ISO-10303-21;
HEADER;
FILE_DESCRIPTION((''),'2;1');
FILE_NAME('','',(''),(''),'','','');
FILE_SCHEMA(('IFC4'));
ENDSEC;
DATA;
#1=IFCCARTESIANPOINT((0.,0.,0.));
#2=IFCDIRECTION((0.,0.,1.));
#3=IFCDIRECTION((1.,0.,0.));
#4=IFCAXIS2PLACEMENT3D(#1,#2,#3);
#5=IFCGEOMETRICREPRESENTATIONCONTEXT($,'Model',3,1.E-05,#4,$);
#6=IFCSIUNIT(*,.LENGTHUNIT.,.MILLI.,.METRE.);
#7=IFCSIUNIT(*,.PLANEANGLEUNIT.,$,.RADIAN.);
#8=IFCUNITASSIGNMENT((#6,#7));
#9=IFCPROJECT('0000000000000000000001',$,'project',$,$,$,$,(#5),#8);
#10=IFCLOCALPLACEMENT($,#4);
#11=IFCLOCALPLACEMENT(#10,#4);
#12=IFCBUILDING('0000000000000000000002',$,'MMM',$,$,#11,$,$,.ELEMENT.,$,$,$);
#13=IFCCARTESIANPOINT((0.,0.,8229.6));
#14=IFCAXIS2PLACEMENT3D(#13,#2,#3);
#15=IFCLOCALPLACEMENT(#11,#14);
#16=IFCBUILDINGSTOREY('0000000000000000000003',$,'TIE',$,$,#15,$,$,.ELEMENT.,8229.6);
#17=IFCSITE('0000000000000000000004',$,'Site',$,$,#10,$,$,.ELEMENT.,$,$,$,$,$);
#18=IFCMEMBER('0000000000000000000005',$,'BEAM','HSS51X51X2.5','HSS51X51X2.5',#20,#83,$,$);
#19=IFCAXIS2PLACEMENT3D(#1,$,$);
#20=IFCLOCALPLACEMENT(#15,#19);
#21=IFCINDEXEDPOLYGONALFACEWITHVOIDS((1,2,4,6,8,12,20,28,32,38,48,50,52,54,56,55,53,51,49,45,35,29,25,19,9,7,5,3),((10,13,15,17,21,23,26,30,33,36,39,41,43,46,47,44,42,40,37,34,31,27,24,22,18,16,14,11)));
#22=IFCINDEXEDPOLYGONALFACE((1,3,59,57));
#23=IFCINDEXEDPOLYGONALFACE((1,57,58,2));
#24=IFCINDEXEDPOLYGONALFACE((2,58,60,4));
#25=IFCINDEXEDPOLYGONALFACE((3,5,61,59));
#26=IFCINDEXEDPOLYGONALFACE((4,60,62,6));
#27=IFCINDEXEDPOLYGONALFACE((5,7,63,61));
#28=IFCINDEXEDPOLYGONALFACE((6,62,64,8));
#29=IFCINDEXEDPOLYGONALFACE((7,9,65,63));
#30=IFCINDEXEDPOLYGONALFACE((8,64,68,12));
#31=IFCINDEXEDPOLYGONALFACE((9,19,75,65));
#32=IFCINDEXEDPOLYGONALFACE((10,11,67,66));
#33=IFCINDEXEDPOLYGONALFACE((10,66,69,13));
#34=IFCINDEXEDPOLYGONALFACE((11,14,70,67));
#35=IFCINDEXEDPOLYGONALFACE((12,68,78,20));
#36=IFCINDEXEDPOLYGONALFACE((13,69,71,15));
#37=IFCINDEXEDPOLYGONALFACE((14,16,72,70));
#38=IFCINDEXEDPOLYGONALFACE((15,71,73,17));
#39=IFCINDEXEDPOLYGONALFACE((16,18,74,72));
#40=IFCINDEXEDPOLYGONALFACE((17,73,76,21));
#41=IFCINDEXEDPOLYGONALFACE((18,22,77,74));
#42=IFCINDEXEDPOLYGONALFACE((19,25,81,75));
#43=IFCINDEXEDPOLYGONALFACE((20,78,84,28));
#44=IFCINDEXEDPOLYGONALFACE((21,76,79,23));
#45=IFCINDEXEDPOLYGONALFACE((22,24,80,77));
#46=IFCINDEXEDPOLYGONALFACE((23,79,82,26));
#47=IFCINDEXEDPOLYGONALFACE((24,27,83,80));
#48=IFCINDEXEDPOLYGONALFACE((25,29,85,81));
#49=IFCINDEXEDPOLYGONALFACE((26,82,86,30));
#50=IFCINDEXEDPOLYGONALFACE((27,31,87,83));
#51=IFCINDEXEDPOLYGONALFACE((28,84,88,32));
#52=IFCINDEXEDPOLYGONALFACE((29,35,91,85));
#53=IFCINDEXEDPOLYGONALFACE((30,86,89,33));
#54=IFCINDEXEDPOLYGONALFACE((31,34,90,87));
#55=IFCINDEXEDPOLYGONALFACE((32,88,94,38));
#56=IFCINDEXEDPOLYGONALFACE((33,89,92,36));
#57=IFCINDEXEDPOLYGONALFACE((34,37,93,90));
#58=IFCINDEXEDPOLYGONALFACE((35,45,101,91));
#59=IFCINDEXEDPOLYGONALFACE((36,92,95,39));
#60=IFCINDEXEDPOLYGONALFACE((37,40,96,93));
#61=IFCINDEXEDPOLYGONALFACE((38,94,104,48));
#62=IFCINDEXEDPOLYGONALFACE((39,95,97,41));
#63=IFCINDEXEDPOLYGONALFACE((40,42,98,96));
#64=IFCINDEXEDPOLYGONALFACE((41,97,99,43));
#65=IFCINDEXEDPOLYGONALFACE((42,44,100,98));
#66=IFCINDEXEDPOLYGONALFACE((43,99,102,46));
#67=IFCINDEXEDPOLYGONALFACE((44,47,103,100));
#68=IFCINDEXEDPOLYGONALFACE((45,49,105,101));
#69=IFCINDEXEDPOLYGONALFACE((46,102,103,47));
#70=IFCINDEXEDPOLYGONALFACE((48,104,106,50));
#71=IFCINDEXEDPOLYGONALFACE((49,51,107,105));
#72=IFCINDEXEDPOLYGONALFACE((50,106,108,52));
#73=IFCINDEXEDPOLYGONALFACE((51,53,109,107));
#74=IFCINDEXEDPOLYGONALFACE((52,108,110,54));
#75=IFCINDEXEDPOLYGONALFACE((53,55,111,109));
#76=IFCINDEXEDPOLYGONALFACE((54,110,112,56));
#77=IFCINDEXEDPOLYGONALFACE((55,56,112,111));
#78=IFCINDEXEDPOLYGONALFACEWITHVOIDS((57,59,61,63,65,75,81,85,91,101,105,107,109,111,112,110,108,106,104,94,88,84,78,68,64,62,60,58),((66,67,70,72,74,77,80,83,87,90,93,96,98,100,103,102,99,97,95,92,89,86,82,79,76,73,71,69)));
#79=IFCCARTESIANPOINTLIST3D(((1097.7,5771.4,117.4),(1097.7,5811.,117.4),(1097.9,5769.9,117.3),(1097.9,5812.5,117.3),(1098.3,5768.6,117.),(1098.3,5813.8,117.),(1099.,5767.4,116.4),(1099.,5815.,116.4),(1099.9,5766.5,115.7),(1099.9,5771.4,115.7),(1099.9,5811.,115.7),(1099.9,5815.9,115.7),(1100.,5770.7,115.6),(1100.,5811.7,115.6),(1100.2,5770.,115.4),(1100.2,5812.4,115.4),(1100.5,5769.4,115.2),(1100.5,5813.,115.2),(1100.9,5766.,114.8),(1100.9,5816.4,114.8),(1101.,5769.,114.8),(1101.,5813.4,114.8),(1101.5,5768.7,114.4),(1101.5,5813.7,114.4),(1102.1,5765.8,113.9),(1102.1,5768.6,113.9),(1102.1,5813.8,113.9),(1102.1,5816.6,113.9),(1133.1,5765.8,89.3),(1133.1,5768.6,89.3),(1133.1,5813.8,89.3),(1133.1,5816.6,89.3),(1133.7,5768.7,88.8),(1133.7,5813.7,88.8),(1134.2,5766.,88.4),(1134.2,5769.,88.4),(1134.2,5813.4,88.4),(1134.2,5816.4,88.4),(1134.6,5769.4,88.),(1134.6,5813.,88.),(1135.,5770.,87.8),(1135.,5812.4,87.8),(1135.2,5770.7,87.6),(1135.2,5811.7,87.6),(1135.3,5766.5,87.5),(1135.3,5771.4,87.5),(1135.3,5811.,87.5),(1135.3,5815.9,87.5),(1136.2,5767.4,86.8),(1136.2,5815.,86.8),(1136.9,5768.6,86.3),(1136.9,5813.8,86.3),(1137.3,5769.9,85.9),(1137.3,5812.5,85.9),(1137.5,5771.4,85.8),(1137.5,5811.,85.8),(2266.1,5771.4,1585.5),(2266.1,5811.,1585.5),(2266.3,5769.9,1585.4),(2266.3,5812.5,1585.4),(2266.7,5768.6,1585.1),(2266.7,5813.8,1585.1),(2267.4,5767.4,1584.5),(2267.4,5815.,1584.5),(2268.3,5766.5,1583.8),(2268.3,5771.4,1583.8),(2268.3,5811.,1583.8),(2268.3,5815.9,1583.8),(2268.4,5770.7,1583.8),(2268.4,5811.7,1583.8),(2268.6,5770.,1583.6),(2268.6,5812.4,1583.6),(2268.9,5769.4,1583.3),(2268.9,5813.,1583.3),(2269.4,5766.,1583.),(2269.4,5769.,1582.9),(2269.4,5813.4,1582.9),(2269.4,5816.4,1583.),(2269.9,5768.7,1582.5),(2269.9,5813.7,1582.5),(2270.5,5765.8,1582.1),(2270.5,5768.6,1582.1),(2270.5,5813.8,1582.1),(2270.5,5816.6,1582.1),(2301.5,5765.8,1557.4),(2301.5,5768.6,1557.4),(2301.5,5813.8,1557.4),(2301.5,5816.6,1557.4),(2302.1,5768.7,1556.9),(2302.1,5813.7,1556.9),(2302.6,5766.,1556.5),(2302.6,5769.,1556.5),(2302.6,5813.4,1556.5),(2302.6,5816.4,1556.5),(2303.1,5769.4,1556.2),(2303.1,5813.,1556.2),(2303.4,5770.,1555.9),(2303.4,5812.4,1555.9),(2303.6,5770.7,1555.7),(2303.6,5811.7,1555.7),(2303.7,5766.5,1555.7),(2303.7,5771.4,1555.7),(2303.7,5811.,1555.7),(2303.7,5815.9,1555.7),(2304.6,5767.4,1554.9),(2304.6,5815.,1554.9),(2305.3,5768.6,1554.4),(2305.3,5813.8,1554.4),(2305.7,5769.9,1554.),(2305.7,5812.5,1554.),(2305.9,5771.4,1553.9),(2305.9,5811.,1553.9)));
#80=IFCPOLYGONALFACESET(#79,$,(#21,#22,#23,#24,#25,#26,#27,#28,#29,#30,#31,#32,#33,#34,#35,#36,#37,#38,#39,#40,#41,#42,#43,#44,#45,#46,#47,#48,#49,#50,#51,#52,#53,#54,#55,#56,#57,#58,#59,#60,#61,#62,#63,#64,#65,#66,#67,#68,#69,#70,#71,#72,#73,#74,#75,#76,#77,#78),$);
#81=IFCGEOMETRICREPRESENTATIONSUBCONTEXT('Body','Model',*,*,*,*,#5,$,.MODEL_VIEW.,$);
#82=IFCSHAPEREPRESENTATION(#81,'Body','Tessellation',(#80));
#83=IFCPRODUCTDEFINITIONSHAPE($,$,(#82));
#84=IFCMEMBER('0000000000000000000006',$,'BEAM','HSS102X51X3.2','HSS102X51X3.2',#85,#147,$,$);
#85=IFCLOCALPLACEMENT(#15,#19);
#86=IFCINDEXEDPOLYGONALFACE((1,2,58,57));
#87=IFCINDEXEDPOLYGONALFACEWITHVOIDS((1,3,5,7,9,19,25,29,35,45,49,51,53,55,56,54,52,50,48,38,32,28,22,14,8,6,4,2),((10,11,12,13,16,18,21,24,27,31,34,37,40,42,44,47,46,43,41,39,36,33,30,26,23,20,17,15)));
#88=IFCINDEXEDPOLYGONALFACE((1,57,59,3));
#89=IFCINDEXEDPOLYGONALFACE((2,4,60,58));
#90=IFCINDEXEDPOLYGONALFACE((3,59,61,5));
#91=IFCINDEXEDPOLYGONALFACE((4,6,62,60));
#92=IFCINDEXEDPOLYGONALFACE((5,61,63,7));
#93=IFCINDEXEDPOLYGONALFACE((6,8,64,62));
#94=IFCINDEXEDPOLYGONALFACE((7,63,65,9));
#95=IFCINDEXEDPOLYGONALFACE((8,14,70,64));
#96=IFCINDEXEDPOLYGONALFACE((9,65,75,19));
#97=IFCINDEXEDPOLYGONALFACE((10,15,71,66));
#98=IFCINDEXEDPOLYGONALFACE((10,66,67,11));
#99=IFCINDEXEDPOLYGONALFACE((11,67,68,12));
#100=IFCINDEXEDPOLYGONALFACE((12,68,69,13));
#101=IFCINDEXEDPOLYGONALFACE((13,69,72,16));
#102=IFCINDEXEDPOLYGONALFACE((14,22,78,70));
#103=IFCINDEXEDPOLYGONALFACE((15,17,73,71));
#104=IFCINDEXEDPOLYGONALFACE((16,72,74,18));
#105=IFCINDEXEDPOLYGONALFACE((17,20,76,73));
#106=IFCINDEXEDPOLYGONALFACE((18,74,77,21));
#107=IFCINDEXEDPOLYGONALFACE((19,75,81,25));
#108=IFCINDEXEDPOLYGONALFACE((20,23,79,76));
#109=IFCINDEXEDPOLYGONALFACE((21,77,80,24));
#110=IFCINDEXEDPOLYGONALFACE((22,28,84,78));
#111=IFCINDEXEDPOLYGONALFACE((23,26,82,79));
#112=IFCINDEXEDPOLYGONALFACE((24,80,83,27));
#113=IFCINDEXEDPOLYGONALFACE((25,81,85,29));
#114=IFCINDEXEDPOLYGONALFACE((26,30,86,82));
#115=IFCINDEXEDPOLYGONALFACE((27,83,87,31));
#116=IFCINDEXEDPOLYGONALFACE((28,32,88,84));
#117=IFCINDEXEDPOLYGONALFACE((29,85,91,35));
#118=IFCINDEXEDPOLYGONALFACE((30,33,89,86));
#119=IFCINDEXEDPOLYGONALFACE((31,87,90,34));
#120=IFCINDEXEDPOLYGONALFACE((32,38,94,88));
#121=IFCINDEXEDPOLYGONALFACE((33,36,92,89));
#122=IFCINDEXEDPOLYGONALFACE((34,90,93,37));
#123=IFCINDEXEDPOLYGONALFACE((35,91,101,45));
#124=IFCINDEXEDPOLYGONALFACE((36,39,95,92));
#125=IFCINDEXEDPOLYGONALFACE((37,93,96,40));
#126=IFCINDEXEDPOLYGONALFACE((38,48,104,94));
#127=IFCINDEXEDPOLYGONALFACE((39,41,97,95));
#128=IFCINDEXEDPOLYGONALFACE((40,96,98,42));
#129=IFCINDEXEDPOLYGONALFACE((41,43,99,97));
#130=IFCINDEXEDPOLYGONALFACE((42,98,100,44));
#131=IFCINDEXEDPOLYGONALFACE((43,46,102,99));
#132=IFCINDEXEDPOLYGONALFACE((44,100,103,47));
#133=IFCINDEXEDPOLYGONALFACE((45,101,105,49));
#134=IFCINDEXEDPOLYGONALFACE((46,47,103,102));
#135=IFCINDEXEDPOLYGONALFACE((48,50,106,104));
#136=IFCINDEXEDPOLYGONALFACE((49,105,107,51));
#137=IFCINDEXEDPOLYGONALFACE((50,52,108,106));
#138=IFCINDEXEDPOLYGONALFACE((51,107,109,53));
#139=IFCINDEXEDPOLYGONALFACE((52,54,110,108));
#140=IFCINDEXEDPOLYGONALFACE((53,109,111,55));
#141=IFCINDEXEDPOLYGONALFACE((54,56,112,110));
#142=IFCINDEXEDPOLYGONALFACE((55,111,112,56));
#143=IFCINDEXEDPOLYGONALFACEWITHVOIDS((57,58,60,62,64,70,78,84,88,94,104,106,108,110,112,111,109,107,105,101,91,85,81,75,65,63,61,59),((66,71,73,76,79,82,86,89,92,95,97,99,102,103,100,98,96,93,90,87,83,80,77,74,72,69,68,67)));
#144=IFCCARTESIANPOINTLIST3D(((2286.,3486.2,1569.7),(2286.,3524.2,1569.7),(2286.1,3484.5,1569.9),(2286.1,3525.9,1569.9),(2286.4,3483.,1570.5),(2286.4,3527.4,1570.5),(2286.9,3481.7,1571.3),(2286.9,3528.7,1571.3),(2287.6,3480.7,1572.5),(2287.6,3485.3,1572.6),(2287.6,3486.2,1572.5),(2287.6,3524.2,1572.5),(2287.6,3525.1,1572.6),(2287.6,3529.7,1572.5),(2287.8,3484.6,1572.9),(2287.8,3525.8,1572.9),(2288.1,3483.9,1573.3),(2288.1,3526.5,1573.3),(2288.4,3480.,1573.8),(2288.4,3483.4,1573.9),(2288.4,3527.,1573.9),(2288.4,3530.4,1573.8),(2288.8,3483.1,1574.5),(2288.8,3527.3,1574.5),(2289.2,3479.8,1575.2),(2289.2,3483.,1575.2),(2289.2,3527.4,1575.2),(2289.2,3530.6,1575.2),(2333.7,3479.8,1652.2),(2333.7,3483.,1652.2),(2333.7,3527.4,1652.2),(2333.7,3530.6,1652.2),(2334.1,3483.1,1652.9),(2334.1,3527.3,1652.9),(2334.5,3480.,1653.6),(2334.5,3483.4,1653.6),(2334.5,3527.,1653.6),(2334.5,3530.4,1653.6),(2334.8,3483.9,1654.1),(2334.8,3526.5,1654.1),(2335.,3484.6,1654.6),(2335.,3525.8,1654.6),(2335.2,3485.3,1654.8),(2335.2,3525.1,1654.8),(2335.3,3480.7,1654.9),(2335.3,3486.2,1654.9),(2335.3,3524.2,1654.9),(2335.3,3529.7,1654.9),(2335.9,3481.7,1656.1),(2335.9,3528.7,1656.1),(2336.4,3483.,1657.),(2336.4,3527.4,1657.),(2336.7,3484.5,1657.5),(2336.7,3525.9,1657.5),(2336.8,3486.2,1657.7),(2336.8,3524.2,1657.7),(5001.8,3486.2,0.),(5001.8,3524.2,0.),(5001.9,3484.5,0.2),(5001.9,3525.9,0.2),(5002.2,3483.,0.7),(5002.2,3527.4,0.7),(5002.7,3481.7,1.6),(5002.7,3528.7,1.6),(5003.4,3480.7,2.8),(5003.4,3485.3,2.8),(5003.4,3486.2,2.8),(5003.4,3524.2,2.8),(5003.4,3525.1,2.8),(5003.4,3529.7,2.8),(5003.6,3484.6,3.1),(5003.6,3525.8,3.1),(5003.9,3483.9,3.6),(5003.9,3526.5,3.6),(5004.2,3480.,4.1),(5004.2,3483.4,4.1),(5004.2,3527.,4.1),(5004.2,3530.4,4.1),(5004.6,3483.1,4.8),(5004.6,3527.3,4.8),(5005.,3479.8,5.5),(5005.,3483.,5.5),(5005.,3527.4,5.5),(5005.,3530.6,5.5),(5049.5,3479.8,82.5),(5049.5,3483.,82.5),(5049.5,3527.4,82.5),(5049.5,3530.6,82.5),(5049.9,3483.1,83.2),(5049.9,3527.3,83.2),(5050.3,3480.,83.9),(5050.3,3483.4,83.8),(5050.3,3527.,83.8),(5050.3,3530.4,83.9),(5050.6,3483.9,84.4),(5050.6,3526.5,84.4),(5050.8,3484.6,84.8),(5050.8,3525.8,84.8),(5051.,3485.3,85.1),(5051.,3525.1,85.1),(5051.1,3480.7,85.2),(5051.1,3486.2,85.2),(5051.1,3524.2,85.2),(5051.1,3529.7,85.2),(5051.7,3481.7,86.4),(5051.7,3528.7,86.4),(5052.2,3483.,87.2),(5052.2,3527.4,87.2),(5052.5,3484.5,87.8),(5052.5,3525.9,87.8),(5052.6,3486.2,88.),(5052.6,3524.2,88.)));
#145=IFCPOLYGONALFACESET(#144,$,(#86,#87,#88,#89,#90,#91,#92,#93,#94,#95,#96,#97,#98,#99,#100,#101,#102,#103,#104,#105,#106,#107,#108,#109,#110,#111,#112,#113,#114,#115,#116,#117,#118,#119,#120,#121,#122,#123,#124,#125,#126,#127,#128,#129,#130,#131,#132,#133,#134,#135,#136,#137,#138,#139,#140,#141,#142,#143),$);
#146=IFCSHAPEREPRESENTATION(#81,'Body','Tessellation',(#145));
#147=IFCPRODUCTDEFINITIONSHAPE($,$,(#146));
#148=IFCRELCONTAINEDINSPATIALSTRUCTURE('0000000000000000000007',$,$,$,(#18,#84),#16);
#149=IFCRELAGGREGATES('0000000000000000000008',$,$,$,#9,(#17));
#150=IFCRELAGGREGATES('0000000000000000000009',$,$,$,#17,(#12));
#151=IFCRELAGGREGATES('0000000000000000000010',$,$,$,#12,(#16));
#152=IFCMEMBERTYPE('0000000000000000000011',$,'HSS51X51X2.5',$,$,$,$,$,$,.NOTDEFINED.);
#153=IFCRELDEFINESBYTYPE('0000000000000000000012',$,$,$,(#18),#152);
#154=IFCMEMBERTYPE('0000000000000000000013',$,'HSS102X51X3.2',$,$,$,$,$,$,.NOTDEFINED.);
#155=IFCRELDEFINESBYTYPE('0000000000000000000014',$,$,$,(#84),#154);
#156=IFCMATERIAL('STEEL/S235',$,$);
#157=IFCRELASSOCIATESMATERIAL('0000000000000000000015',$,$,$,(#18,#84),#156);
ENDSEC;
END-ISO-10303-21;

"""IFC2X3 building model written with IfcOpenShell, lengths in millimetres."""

from ifc_helpers import new_model, si_unit, frame, origin_with_axes, origin_2d_with_axis, place, context, subcontext, project, spatial, hollow_rectangle, extrude, material, type_object, element, save


model = new_model("IFC2X3")

# Units and contexts
model_context = context("Model", 3, precision=1e-05, world=origin_with_axes())
body_context = subcontext(model_context, "Body", "Model", "MODEL_VIEW")
ifc_project = project(units=[si_unit("LENGTHUNIT", "METRE", prefix="MILLI"), si_unit("PLANEANGLEUNIT", "RADIAN")], contexts=[model_context])

# Site, building, storey
site_placement = place(None, origin_with_axes())
site = spatial("IfcSite", under=ifc_project, at=site_placement, Name="Site", CompositionType="ELEMENT")
building_placement = place(site_placement, origin_with_axes())
building = spatial("IfcBuilding", under=site, at=building_placement, Name="MMM", CompositionType="ELEMENT")
storey_placement = place(building_placement, frame((0.0, 0.0, 8229.6), z_axis=(0.0, 0.0, 1.0), x_axis=(1.0, 0.0, 0.0)))
storey = spatial("IfcBuildingStorey", under=building, at=storey_placement, Name="TIE", CompositionType="ELEMENT", Elevation=8229.6)

# Shared definitions
ifc_material = material(Name="STEEL/S235")

# Members
member_type_1 = type_object("IfcMemberType", Name="HSS51X51X2.5", PredefinedType="NOTDEFINED")
for number, where, z_axis, x_axis, name in (
    (1, (1117.6, 5791.2, 101.6), (-0.782448, 0.0, 0.622716), (0.622716, 0.0, 0.782448), "BEAM"),
):
    element("IfcMember", number, at=place(storey_placement, frame(where, z_axis=z_axis, x_axis=x_axis)), inside=storey, type_object=member_type_1, material=ifc_material, Name=name, Description="HSS51X51X2.5", ObjectType="HSS51X51X2.5", context=body_context, shape_type="SweptSolid", body=[
        extrude(hollow_rectangle(XDim=50.8, YDim=50.8, WallThickness=2.8, InnerFilletRadius=2.8, OuterFilletRadius=5.6, at=origin_2d_with_axis()), frame((1876.3, 0.0, 0.0), z_axis=(-1.0, 0.0, 0.0), x_axis=(0.0, -1.0, 0.0)), (0.0, 0.0, 1.0), 1876.3),
    ])
member_type_2 = type_object("IfcMemberType", Name="HSS102X51X3.2", PredefinedType="NOTDEFINED")
for number, where, z_axis, x_axis, name in (
    (2, (2311.4, 3505.2, 1613.7), (0.500422, 0.0, 0.865782), (0.865782, 0.0, -0.500422), "BEAM"),
):
    element("IfcMember", number, at=place(storey_placement, frame(where, z_axis=z_axis, x_axis=x_axis)), inside=storey, type_object=member_type_2, material=ifc_material, Name=name, Description="HSS102X51X3.2", ObjectType="HSS102X51X3.2", context=body_context, shape_type="SweptSolid", body=[
        extrude(hollow_rectangle(XDim=50.8, YDim=101.6, WallThickness=3.2, InnerFilletRadius=3.2, OuterFilletRadius=6.4, at=origin_2d_with_axis()), frame((3136.8, 0.0, 0.0), z_axis=(-1.0, 0.0, 0.0), x_axis=(0.0, -1.0, 0.0)), (0.0, 0.0, 1.0), 3136.8),
    ])

save(model, "model.ifc")
